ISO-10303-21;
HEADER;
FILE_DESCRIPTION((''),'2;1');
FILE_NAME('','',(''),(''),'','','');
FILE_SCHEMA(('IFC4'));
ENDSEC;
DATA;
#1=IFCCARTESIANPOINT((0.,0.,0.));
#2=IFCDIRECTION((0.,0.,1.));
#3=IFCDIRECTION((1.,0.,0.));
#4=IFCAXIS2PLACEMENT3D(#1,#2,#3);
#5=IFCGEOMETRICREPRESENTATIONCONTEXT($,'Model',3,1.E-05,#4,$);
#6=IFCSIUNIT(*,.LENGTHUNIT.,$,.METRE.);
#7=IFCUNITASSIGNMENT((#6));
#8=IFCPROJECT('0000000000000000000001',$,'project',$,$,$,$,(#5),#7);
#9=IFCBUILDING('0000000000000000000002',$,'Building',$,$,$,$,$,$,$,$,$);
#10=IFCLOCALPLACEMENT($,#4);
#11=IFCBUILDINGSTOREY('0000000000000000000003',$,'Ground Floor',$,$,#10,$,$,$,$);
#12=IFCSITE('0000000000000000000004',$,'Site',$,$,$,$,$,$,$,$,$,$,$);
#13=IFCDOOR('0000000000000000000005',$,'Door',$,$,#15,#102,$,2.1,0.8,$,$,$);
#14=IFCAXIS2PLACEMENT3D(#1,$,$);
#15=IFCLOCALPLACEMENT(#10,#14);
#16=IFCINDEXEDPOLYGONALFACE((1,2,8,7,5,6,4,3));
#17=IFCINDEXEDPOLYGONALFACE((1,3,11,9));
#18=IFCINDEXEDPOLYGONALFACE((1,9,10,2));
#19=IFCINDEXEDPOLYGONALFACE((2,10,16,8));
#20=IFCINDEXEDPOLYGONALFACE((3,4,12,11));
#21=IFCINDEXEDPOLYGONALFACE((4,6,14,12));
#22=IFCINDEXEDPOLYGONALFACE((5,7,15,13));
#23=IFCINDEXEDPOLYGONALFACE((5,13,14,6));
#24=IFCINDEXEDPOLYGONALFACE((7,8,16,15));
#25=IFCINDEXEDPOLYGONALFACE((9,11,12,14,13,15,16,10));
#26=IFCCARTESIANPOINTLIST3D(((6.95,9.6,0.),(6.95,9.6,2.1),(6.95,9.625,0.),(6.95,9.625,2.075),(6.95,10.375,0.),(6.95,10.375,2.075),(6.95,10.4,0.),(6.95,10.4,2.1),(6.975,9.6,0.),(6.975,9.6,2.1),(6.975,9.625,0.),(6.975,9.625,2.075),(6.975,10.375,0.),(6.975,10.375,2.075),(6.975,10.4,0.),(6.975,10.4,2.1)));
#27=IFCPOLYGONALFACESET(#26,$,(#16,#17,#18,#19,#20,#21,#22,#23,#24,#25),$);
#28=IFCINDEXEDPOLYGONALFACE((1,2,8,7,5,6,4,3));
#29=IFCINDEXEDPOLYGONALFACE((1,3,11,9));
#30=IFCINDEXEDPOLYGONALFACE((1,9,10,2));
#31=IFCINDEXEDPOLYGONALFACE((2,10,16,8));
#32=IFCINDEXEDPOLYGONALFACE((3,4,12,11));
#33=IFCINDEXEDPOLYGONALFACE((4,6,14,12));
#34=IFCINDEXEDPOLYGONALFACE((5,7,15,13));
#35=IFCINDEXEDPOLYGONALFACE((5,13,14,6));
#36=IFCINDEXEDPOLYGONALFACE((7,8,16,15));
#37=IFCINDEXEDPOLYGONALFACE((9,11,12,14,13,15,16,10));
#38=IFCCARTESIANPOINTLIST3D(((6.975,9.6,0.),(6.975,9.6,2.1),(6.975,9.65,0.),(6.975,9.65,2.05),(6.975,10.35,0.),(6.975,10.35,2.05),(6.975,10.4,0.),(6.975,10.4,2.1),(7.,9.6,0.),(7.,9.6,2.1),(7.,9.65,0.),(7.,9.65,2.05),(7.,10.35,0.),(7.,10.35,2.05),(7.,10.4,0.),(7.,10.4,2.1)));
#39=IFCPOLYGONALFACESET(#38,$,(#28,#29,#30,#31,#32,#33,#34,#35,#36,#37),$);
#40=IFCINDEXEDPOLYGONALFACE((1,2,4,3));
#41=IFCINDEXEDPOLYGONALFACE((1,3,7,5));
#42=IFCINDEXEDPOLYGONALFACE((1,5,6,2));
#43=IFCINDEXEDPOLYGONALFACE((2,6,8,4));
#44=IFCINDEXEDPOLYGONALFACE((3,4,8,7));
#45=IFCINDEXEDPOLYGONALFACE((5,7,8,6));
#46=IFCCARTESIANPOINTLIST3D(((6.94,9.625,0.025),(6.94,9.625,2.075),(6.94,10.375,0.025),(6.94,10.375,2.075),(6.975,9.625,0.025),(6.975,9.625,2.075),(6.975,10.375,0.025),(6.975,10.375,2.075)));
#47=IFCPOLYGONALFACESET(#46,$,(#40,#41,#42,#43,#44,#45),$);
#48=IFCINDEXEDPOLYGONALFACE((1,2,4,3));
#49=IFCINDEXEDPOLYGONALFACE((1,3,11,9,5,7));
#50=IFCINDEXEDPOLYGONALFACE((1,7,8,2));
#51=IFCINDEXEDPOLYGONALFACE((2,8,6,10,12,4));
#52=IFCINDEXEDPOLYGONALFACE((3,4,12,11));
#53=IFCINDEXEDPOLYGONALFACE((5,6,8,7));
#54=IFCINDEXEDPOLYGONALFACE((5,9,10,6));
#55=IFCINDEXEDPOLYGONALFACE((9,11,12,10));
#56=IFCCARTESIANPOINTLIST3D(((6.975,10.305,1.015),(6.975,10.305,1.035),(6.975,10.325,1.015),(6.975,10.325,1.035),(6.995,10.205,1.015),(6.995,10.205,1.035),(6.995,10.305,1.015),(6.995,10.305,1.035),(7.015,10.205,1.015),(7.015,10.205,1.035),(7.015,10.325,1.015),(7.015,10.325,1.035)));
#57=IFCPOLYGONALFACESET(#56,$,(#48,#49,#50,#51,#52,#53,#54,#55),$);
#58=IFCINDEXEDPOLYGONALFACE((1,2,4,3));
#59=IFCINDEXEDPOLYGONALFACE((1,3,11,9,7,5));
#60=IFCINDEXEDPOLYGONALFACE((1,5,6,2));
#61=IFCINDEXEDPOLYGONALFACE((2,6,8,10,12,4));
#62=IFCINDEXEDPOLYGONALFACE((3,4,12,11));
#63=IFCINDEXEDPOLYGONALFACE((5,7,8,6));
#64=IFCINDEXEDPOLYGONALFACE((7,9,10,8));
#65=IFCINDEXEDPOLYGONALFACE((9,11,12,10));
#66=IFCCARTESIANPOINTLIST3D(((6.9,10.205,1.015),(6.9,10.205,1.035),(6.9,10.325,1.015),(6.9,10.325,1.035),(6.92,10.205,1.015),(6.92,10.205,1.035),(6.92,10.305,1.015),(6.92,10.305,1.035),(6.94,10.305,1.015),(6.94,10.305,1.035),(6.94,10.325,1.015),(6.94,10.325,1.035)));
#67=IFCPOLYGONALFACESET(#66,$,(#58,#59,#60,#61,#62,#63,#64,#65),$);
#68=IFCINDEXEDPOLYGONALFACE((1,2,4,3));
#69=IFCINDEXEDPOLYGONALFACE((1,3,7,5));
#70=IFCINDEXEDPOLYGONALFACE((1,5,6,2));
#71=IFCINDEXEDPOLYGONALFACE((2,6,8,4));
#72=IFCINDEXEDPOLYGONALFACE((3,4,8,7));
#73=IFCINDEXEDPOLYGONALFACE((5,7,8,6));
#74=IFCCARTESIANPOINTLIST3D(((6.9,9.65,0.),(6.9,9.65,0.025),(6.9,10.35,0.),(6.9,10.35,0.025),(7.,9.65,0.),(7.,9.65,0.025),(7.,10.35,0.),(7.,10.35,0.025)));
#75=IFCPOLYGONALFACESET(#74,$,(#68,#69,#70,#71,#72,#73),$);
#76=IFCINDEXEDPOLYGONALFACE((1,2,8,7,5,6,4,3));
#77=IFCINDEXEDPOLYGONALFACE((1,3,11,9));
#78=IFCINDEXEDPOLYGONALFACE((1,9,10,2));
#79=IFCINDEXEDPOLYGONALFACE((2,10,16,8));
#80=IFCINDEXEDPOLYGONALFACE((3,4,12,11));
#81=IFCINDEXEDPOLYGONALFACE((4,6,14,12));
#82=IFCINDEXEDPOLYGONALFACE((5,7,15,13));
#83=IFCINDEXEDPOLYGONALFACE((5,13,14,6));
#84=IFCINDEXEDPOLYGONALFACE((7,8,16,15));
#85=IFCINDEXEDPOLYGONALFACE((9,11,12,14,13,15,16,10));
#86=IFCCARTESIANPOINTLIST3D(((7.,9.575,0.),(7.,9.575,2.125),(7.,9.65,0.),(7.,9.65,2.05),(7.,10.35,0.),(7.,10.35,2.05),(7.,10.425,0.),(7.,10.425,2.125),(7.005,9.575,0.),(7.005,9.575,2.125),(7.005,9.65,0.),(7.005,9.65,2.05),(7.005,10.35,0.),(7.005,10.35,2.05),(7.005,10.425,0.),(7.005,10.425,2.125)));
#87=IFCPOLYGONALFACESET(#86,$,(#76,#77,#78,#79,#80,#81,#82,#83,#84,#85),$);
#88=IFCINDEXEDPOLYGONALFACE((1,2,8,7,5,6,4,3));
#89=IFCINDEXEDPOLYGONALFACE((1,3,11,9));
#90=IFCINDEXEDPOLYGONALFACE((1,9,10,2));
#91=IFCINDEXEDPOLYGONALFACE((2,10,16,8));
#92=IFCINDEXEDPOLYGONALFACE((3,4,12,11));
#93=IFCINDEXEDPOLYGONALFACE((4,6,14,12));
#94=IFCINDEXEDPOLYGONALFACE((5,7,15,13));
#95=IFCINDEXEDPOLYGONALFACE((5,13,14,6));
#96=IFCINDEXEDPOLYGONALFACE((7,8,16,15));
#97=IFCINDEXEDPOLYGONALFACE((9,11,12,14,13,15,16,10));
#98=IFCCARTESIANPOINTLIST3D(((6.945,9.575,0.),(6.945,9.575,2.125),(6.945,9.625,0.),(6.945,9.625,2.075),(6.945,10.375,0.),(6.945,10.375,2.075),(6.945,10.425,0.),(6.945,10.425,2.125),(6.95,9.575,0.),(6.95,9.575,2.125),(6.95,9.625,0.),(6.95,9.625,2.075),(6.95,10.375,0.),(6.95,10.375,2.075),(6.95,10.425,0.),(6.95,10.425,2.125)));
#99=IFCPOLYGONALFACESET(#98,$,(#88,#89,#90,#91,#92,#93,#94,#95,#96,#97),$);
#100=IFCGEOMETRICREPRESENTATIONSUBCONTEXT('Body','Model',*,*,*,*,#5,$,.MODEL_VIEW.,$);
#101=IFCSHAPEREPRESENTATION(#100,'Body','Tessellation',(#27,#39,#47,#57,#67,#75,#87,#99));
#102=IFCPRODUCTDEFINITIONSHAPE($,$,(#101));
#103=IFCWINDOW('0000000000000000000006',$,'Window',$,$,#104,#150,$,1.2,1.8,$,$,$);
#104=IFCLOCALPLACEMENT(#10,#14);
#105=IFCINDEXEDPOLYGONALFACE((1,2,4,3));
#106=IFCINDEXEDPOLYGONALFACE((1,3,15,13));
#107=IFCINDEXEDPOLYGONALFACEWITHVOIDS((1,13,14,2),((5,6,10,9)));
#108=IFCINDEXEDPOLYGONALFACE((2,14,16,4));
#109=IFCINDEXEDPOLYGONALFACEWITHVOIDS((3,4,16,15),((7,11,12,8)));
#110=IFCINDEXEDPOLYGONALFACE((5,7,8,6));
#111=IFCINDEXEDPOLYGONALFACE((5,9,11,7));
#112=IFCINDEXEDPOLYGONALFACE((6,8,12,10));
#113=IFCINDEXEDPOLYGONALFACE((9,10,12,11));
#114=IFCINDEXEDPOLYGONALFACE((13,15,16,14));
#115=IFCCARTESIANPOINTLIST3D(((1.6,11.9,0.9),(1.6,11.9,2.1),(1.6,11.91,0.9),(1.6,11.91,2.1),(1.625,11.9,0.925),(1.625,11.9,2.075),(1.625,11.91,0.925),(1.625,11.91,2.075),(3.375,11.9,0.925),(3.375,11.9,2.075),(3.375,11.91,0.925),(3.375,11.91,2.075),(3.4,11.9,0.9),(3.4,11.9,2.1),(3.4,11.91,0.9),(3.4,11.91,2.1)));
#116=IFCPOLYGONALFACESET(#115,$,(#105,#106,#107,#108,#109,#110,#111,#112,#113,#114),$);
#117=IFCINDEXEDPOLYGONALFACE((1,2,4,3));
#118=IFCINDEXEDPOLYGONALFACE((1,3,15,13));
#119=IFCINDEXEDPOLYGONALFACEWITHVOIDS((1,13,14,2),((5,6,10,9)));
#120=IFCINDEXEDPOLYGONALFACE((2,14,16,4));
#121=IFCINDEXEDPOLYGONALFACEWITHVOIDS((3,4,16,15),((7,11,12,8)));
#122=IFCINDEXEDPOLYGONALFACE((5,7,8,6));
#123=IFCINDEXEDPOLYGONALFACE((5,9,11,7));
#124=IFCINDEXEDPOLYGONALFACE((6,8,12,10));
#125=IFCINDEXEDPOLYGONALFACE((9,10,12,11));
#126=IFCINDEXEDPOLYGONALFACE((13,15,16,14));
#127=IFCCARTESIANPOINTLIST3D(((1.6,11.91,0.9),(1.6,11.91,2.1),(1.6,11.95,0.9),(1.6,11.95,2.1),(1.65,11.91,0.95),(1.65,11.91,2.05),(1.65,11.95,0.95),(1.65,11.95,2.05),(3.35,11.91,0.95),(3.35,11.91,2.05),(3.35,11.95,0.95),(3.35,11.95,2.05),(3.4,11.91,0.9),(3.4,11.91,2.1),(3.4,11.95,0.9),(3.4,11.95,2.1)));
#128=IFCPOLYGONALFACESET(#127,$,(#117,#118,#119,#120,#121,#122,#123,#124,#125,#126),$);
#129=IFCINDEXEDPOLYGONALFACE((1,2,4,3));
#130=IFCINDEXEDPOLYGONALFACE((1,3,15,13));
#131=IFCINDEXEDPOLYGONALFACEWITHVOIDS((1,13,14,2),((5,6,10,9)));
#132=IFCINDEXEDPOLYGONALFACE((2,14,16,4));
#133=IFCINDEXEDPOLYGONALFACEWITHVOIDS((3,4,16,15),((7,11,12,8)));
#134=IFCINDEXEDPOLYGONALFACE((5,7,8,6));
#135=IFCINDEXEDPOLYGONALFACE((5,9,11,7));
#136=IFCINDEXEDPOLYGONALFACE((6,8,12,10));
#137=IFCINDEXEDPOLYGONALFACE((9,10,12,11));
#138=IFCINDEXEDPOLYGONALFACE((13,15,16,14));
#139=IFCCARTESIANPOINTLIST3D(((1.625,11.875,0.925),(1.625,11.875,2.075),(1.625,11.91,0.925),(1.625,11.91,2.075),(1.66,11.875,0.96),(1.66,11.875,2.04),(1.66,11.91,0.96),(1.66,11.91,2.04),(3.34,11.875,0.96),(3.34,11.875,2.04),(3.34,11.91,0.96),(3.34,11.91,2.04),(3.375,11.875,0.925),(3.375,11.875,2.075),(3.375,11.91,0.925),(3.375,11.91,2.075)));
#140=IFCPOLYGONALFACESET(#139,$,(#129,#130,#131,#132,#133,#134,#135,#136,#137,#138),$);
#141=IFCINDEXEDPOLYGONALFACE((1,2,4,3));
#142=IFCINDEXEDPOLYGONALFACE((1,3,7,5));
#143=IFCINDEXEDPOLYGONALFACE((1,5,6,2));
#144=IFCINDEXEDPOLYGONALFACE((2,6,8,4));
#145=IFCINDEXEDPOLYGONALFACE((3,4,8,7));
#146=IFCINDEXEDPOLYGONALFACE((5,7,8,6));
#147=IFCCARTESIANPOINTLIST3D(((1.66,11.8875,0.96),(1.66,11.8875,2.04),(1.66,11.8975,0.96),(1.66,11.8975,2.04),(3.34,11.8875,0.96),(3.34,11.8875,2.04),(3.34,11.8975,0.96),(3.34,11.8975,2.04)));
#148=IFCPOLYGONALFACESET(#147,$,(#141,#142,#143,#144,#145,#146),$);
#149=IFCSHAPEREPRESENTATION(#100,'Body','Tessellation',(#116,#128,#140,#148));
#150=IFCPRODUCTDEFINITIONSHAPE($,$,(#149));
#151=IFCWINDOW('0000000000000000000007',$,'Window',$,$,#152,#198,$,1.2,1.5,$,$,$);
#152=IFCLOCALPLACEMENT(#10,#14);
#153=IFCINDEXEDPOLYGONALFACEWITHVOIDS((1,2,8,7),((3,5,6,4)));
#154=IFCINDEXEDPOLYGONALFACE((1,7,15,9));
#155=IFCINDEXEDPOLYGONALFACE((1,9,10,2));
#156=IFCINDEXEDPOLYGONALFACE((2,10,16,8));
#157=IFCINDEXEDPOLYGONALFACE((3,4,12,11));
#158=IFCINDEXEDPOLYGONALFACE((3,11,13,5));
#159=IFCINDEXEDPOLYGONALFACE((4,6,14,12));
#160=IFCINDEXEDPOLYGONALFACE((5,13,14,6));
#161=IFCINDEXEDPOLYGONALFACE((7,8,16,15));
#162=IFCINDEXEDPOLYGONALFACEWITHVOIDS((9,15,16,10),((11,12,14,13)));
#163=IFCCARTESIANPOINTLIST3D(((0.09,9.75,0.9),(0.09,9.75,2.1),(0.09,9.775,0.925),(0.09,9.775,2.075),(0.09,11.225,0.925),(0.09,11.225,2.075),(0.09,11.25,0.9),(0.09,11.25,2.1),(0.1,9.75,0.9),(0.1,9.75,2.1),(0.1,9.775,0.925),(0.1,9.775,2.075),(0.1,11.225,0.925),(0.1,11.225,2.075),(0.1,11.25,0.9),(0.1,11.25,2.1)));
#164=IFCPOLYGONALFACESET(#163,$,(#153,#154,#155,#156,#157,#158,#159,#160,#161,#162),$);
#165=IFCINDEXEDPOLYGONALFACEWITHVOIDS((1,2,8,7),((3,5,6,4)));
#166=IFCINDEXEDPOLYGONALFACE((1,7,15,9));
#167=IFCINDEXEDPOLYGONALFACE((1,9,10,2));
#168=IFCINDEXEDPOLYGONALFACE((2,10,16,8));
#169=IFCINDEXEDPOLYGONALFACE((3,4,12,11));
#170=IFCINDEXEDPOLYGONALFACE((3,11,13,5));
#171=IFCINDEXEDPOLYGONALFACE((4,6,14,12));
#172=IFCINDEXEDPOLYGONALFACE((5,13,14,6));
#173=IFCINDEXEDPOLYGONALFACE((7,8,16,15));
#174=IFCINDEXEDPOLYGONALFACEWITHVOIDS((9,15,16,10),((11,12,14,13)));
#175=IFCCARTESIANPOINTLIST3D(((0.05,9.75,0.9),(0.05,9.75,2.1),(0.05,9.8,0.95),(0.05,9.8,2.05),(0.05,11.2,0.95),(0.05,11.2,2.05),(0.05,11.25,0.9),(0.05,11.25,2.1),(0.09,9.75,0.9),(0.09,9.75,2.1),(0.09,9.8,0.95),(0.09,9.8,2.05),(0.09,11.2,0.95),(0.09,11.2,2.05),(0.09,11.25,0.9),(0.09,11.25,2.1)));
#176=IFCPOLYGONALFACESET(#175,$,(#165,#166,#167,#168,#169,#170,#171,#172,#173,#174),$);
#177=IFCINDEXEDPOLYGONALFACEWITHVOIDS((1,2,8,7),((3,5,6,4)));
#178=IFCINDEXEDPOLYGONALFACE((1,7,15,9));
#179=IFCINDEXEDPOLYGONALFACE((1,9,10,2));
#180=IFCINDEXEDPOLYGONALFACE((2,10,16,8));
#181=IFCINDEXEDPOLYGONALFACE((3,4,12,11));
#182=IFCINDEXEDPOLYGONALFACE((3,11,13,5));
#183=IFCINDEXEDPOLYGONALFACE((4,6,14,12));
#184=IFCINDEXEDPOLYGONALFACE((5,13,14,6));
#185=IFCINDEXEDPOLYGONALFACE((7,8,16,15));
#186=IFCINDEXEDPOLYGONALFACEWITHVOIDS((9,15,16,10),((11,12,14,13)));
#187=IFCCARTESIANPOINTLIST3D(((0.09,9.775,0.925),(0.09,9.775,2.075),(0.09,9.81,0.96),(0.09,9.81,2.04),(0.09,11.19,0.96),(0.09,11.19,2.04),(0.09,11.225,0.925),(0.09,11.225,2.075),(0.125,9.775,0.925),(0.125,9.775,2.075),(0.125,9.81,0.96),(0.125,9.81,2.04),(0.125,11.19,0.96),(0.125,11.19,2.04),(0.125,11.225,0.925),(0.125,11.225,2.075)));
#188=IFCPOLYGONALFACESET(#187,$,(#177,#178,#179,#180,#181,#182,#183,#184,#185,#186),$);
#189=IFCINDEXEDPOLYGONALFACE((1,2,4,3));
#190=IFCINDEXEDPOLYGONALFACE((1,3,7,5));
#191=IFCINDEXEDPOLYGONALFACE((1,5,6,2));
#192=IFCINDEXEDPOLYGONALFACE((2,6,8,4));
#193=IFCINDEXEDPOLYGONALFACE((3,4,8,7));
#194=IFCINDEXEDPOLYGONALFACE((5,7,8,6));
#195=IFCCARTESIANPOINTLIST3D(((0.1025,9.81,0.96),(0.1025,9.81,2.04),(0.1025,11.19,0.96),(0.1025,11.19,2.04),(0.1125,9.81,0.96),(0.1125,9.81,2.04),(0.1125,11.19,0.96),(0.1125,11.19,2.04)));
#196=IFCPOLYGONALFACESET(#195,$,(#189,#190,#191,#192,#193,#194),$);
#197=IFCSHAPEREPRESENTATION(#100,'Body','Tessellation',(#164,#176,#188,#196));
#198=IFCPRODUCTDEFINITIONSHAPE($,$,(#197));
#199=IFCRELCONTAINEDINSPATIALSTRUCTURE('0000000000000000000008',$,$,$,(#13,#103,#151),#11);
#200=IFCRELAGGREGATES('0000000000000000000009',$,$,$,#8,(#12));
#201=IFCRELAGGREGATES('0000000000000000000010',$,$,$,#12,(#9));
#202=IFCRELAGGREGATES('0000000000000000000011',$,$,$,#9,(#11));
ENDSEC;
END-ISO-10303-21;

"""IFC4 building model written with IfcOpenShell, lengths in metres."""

from ifc_helpers import new_model, si_unit, frame, origin_with_axes, place, context, subcontext, project, spatial, line, indexed_curve, outline, extrude, element, save


model = new_model("IFC4")

# Units and contexts
model_context = context("Model", 3, precision=1e-05, world=origin_with_axes())
body_context = subcontext(model_context, "Body", "Model", "MODEL_VIEW")
ifc_project = project(units=[si_unit("LENGTHUNIT", "METRE")], contexts=[model_context])

# Site, building, storey
site = spatial("IfcSite", under=ifc_project, Name="Site")
building = spatial("IfcBuilding", under=site, Name="Building")
storey_placement = place(None, origin_with_axes())
storey = spatial("IfcBuildingStorey", under=building, at=storey_placement, Name="Ground Floor")

# Door
door_1_placement = place(storey_placement, frame((7.0, 9.6, 0.0), z_axis=(0.0, 0.0, 1.0), x_axis=(0.0, 1.0, 0.0)))
element("IfcDoor", 1, at=door_1_placement, inside=storey, Name="Door", OverallHeight=2.1, OverallWidth=0.8, context=body_context, shape_type="SweptSolid", body=[
    extrude(outline(indexed_curve([(0.0, 0.0), (0.0, 2.1), (0.8, 2.1), (0.8, 0.0), (0.775, 0.0), (0.775, 2.075), (0.025, 2.075), (0.025, 0.0)], segments=[line(1, 2, 3, 4, 5, 6, 7, 8, 1)])), frame((0.0, 0.025, 0.0), z_axis=(0.0, -1.0, 0.0), x_axis=(1.0, 0.0, 0.0)), (0.0, 0.0, -1.0), 0.025),
    extrude(outline(indexed_curve([(0.0, 0.0), (0.0, 2.1), (0.8, 2.1), (0.8, 0.0), (0.75, 0.0), (0.75, 2.05), (0.05, 2.05), (0.05, 0.0)], segments=[line(1, 2, 3, 4, 5, 6, 7, 8, 1)])), frame((0.0, 0.0, 0.0), z_axis=(0.0, -1.0, 0.0), x_axis=(1.0, 0.0, 0.0)), (0.0, 0.0, -1.0), 0.025),
    extrude(outline(indexed_curve([(0.0, 0.0), (0.75, 0.0), (0.75, 0.035), (0.0, 0.035)], segments=[line(1, 2, 3, 4, 1)])), frame((0.025, 0.025, 0.025), z_axis=(0.0, 0.0, 1.0), x_axis=(1.0, 0.0, 0.0)), (0.0, 0.0, 1.0), 2.05),
    extrude(outline(indexed_curve([(0.0, 0.0), (0.0, -0.04), (-0.12, -0.04), (-0.12, -0.02), (-0.02, -0.02), (-0.02, 0.0)], segments=[line(1, 2, 3, 4, 5, 6, 1)])), frame((0.725, 0.025, 1.015), z_axis=(0.0, 0.0, 1.0), x_axis=(1.0, 0.0, 0.0)), (0.0, 0.0, 1.0), 0.02),
    extrude(outline(indexed_curve([(0.0, 0.0), (0.0, 0.04), (-0.12, 0.04), (-0.12, 0.02), (-0.02, 0.02), (-0.02, 0.0)], segments=[line(1, 2, 3, 4, 5, 6, 1)])), frame((0.725, 0.06, 1.015), z_axis=(0.0, 0.0, 1.0), x_axis=(1.0, 0.0, 0.0)), (0.0, 0.0, 1.0), 0.02),
    extrude(outline(indexed_curve([(0.0, 0.0), (0.7, 0.0), (0.7, 0.1), (0.0, 0.1)], segments=[line(1, 2, 3, 4, 1)])), frame((0.05, 0.0, 0.0), z_axis=(0.0, 0.0, 1.0), x_axis=(1.0, 0.0, 0.0)), (0.0, 0.0, 1.0), 0.025),
    extrude(outline(indexed_curve([(0.0, 0.0), (0.0, 2.125), (0.85, 2.125), (0.85, 0.0), (0.775, 0.0), (0.775, 2.05), (0.075, 2.05), (0.075, 0.0)], segments=[line(1, 2, 3, 4, 5, 6, 7, 8, 1)])), frame((-0.025, -0.005, 0.0), z_axis=(0.0, -1.0, 0.0), x_axis=(1.0, 0.0, 0.0)), (0.0, 0.0, -1.0), 0.005),
    extrude(outline(indexed_curve([(0.0, 0.0), (0.0, 2.125), (0.85, 2.125), (0.85, 0.0), (0.8, 0.0), (0.8, 2.075), (0.05, 2.075), (0.05, 0.0)], segments=[line(1, 2, 3, 4, 5, 6, 7, 8, 1)])), frame((-0.025, 0.05, 0.0), z_axis=(0.0, -1.0, 0.0), x_axis=(1.0, 0.0, 0.0)), (0.0, 0.0, -1.0), 0.005),
])

# Windows
window_1_placement = place(storey_placement, frame((3.4, 12.0, 0.9), z_axis=(0.0, 0.0, 1.0), x_axis=(-1.0, 0.0, 0.0)))
element("IfcWindow", 2, at=window_1_placement, inside=storey, Name="Window", OverallHeight=1.2, OverallWidth=1.8, context=body_context, shape_type="SweptSolid", body=[
    extrude(outline(indexed_curve([(0.0, 0.0), (1.8, 0.0), (1.8, 1.2), (0.0, 1.2)], segments=[line(1, 2, 3, 4, 1)]), holes=[indexed_curve([(0.025, 0.025), (1.775, 0.025), (1.775, 1.175), (0.025, 1.175)], segments=[line(1, 2, 3, 4, 1)])]), frame((0.0, 0.09, 0.0), z_axis=(0.0, -1.0, 0.0), x_axis=(1.0, 0.0, 0.0)), (0.0, 0.0, -1.0), 0.01),
    extrude(outline(indexed_curve([(0.0, 0.0), (1.8, 0.0), (1.8, 1.2), (0.0, 1.2)], segments=[line(1, 2, 3, 4, 1)]), holes=[indexed_curve([(0.05, 0.05), (1.75, 0.05), (1.75, 1.15), (0.05, 1.15)], segments=[line(1, 2, 3, 4, 1)])]), frame((0.0, 0.05, 0.0), z_axis=(0.0, -1.0, 0.0), x_axis=(1.0, 0.0, 0.0)), (0.0, 0.0, -1.0), 0.04),
    extrude(outline(indexed_curve([(0.0, 0.0), (1.75, 0.0), (1.75, 1.15), (0.0, 1.15)], segments=[line(1, 2, 3, 4, 1)]), holes=[indexed_curve([(0.035, 0.035), (1.715, 0.035), (1.715, 1.115), (0.035, 1.115)], segments=[line(1, 2, 3, 4, 1)])]), frame((0.025, 0.09, 0.025), z_axis=(0.0, -1.0, 0.0), x_axis=(1.0, 0.0, 0.0)), (0.0, 0.0, -1.0), 0.035),
    extrude(outline(indexed_curve([(0.035, 0.035), (1.715, 0.035), (1.715, 1.115), (0.035, 1.115)], segments=[line(1, 2, 3, 4, 1)])), frame((0.025, 0.1025, 0.025), z_axis=(0.0, -1.0, 0.0), x_axis=(1.0, 0.0, 0.0)), (0.0, 0.0, -1.0), 0.01),
])
window_2_placement = place(storey_placement, frame((0.0, 11.25, 0.9), z_axis=(0.0, 0.0, 1.0), x_axis=(0.0, -1.0, 0.0)))
element("IfcWindow", 3, at=window_2_placement, inside=storey, Name="Window", OverallHeight=1.2, OverallWidth=1.5, context=body_context, shape_type="SweptSolid", body=[
    extrude(outline(indexed_curve([(0.0, 0.0), (1.5, 0.0), (1.5, 1.2), (0.0, 1.2)], segments=[line(1, 2, 3, 4, 1)]), holes=[indexed_curve([(0.025, 0.025), (1.475, 0.025), (1.475, 1.175), (0.025, 1.175)], segments=[line(1, 2, 3, 4, 1)])]), frame((0.0, 0.09, 0.0), z_axis=(0.0, -1.0, 0.0), x_axis=(1.0, 0.0, 0.0)), (0.0, 0.0, -1.0), 0.01),
    extrude(outline(indexed_curve([(0.0, 0.0), (1.5, 0.0), (1.5, 1.2), (0.0, 1.2)], segments=[line(1, 2, 3, 4, 1)]), holes=[indexed_curve([(0.05, 0.05), (1.45, 0.05), (1.45, 1.15), (0.05, 1.15)], segments=[line(1, 2, 3, 4, 1)])]), frame((0.0, 0.05, 0.0), z_axis=(0.0, -1.0, 0.0), x_axis=(1.0, 0.0, 0.0)), (0.0, 0.0, -1.0), 0.04),
    extrude(outline(indexed_curve([(0.0, 0.0), (1.45, 0.0), (1.45, 1.15), (0.0, 1.15)], segments=[line(1, 2, 3, 4, 1)]), holes=[indexed_curve([(0.035, 0.035), (1.415, 0.035), (1.415, 1.115), (0.035, 1.115)], segments=[line(1, 2, 3, 4, 1)])]), frame((0.025, 0.09, 0.025), z_axis=(0.0, -1.0, 0.0), x_axis=(1.0, 0.0, 0.0)), (0.0, 0.0, -1.0), 0.035),
    extrude(outline(indexed_curve([(0.035, 0.035), (1.415, 0.035), (1.415, 1.115), (0.035, 1.115)], segments=[line(1, 2, 3, 4, 1)])), frame((0.025, 0.1025, 0.025), z_axis=(0.0, -1.0, 0.0), x_axis=(1.0, 0.0, 0.0)), (0.0, 0.0, -1.0), 0.01),
])

save(model, "model.ifc")
